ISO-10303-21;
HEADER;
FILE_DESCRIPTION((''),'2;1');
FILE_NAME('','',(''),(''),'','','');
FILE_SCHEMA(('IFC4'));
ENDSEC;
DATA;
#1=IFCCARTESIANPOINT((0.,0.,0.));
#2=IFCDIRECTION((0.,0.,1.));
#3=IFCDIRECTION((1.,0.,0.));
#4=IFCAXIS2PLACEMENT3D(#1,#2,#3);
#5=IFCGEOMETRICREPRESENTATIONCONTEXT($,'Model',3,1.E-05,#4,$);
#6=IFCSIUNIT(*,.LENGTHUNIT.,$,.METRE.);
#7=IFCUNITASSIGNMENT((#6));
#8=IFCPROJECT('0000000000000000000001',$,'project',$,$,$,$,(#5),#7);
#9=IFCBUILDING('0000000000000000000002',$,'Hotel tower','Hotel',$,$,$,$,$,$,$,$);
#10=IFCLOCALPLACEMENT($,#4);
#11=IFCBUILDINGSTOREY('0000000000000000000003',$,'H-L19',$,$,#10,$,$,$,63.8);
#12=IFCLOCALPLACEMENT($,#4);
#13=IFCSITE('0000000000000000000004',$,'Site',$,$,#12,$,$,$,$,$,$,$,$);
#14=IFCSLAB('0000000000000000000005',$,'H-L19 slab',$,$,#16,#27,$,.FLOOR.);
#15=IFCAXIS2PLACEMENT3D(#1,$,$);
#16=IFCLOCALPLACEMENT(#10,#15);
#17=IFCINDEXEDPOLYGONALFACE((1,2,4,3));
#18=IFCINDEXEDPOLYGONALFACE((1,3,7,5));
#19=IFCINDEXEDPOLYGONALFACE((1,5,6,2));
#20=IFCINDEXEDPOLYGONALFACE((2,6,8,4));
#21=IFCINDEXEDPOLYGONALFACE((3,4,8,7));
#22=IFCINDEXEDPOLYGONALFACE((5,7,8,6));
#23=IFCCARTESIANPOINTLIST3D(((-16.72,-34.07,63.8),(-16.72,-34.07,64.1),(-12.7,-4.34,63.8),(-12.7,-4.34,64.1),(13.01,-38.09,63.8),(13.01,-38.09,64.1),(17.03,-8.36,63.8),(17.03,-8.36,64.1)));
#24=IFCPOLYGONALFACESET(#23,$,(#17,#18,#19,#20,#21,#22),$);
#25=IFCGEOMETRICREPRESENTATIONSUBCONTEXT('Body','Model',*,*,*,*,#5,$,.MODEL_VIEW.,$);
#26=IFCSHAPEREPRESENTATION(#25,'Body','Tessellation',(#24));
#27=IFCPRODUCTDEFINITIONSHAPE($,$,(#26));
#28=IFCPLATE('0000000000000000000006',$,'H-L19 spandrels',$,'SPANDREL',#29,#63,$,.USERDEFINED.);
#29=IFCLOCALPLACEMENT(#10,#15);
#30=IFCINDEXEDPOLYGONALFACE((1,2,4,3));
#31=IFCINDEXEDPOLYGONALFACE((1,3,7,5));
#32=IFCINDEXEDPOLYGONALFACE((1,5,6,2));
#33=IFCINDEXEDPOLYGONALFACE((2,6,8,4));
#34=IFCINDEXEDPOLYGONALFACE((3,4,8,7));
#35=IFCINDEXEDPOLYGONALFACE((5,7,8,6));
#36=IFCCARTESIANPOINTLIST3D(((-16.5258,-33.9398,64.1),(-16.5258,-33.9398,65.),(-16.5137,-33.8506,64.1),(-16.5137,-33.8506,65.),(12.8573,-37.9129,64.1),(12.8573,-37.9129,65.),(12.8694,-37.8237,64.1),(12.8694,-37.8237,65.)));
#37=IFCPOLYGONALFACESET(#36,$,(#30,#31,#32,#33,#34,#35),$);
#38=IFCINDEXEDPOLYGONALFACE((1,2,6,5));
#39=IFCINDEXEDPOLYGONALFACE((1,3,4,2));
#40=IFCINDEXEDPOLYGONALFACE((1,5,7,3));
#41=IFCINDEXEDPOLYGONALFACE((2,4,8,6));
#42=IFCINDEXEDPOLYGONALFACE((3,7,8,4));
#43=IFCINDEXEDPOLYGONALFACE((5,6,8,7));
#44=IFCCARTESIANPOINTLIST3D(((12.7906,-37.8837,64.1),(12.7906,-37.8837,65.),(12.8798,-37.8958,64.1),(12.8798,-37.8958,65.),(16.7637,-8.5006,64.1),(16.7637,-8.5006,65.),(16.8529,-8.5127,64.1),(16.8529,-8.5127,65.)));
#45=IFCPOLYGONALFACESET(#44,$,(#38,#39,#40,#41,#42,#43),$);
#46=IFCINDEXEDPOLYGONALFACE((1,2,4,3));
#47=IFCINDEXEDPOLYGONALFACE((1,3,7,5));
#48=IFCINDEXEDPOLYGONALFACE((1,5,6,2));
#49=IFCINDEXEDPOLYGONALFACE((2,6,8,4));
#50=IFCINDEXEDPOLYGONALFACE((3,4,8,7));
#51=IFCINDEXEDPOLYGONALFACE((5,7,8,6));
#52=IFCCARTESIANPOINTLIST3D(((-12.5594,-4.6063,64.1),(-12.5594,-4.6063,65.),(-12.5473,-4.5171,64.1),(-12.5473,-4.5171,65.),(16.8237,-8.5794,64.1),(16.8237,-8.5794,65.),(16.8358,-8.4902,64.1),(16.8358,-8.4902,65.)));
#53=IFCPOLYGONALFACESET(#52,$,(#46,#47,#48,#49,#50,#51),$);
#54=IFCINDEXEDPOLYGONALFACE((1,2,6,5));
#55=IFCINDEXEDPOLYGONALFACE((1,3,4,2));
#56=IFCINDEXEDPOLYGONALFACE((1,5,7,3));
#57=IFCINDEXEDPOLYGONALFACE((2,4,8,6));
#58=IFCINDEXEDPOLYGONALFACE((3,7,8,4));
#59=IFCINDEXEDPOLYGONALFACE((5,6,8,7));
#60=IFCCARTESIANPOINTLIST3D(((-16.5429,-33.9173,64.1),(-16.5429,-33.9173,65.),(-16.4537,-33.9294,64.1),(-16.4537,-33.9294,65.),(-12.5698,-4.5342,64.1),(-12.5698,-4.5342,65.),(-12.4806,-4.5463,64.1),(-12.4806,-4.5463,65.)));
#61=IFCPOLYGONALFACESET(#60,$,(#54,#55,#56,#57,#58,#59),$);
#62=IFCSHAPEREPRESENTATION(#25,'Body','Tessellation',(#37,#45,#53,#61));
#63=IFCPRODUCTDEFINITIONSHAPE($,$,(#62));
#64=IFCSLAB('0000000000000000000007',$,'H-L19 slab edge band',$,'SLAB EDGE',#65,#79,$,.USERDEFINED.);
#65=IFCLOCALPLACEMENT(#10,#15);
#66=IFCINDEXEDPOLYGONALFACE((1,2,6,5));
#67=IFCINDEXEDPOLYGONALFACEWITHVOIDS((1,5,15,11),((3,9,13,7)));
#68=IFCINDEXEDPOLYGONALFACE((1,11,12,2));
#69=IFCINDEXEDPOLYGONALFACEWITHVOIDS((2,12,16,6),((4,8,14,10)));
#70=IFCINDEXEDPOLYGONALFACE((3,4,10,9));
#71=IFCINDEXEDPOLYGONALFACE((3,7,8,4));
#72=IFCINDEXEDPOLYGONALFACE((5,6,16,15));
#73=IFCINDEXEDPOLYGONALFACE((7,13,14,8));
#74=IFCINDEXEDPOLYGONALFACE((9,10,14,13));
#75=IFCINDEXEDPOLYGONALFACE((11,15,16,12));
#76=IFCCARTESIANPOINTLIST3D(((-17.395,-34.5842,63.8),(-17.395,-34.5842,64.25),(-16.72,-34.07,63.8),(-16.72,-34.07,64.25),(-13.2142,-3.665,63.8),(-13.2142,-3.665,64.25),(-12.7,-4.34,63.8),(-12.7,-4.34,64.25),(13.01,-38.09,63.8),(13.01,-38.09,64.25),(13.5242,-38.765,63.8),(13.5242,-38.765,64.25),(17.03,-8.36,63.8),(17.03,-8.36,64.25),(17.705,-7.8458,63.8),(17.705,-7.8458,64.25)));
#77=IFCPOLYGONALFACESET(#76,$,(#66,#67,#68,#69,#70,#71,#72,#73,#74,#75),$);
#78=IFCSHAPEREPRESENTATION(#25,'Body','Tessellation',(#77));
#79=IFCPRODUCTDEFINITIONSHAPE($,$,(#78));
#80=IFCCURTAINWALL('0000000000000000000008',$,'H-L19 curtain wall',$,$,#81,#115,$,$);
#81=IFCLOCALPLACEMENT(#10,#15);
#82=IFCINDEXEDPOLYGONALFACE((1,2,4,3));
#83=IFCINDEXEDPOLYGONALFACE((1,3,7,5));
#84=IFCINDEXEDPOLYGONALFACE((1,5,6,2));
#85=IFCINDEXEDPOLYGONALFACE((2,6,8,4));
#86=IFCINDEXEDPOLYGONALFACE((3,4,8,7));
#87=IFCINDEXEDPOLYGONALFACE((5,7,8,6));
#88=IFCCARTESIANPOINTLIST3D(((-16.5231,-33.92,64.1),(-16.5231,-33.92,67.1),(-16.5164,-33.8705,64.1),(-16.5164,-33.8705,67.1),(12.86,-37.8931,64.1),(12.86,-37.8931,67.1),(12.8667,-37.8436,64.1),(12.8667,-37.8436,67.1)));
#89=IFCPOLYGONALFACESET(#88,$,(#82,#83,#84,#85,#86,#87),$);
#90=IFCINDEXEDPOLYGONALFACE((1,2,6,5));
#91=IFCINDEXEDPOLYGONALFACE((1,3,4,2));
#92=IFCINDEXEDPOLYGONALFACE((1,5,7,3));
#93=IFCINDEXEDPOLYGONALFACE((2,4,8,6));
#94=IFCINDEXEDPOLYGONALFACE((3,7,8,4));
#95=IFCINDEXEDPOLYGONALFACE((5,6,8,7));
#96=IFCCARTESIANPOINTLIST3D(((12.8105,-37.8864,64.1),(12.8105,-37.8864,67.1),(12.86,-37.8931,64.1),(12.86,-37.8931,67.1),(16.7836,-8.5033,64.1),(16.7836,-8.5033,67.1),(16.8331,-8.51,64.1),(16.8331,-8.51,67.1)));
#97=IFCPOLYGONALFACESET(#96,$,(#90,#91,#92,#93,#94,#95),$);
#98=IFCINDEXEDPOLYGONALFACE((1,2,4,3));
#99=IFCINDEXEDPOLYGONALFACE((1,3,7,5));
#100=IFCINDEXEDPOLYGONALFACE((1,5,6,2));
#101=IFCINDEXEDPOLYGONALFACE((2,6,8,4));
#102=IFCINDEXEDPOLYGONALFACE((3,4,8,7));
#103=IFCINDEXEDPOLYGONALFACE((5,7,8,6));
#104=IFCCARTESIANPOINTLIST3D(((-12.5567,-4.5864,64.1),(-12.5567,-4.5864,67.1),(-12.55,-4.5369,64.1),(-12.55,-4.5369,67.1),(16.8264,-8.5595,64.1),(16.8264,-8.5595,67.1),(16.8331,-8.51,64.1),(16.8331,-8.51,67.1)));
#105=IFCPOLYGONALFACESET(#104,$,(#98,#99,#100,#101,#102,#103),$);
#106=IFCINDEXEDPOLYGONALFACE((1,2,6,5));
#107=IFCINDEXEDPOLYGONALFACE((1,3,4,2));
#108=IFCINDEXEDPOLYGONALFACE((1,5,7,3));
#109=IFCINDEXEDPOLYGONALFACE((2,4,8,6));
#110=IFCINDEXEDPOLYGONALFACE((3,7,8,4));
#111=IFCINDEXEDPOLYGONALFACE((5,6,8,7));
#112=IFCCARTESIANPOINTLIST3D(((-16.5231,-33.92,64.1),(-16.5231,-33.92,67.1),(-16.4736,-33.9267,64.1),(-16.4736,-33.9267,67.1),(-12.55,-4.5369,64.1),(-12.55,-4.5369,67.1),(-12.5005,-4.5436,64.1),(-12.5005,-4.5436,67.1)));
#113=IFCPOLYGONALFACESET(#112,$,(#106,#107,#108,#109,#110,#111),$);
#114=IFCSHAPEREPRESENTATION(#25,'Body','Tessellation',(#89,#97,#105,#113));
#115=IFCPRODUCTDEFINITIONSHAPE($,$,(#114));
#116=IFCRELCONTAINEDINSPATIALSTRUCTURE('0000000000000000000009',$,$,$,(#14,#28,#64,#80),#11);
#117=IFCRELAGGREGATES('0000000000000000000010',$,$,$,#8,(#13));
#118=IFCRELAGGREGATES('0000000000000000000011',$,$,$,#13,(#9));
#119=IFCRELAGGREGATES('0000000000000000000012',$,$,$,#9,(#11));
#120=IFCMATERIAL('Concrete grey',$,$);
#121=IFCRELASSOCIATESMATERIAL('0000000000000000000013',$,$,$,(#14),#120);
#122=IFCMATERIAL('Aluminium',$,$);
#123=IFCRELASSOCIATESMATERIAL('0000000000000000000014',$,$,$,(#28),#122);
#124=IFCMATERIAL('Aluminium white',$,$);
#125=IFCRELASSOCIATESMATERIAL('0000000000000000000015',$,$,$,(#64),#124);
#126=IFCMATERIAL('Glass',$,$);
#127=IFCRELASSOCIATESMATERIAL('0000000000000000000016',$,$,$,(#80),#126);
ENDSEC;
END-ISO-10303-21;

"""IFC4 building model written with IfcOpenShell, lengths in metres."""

from ifc_helpers import new_model, si_unit, frame, origin_with_axes, place, context, subcontext, project, spatial, polyline, outline, extrude, material, element, save


model = new_model("IFC4")

# Units and contexts
model_context = context("Model", 3, precision=1e-05, world=origin_with_axes())
body_context = subcontext(model_context, "Body", "Model", "MODEL_VIEW")
ifc_project = project(units=[si_unit("LENGTHUNIT", "METRE")], contexts=[model_context])

# Site, building, storey
site_placement = place(None, origin_with_axes())
site = spatial("IfcSite", under=ifc_project, at=site_placement, Name="Site")
building = spatial("IfcBuilding", under=site, Name="Hotel tower", Description="Hotel")
storey_placement = place(None, origin_with_axes())
storey = spatial("IfcBuildingStorey", under=building, at=storey_placement, Name="H-L19", Elevation=63.8)

# Shared definitions
ifc_material_1 = material(Name="Aluminium")

# Slab
ifc_material_2 = material(Name="Concrete grey")
slab_1_placement = place(storey_placement, origin_with_axes())
element("IfcSlab", 1, at=slab_1_placement, inside=storey, material=ifc_material_2, Name="H-L19 slab", PredefinedType="FLOOR", context=body_context, shape_type="SweptSolid", body=[
    extrude(outline(polyline([(-16.72, -34.07), (13.01, -38.09), (17.03, -8.36), (-12.7, -4.34), (-16.72, -34.07)])), frame((0.0, 0.0, 63.8), z_axis=(0.0, 0.0, 1.0), x_axis=(1.0, 0.0, 0.0)), (0.0, 0.0, 1.0), 0.3),
])

# Plate
plate_placement = place(storey_placement, origin_with_axes())
element("IfcPlate", 2, at=plate_placement, inside=storey, material=ifc_material_1, Name="H-L19 spandrels", ObjectType="SPANDREL", PredefinedType="USERDEFINED", context=body_context, shape_type="SweptSolid", body=[
    extrude(outline(polyline([(-16.5258, -33.9398), (12.8573, -37.9129), (12.8694, -37.8237), (-16.5137, -33.8506), (-16.5258, -33.9398)])), frame((0.0, 0.0, 64.1), z_axis=(0.0, 0.0, 1.0), x_axis=(1.0, 0.0, 0.0)), (0.0, 0.0, 1.0), 0.9),
    extrude(outline(polyline([(12.8798, -37.8958), (16.8529, -8.5127), (16.7637, -8.5006), (12.7906, -37.8837), (12.8798, -37.8958)])), frame((0.0, 0.0, 64.1), z_axis=(0.0, 0.0, 1.0), x_axis=(1.0, 0.0, 0.0)), (0.0, 0.0, 1.0), 0.9),
    extrude(outline(polyline([(16.8358, -8.4902), (-12.5473, -4.5171), (-12.5594, -4.6063), (16.8237, -8.5794), (16.8358, -8.4902)])), frame((0.0, 0.0, 64.1), z_axis=(0.0, 0.0, 1.0), x_axis=(1.0, 0.0, 0.0)), (0.0, 0.0, 1.0), 0.9),
    extrude(outline(polyline([(-12.5698, -4.5342), (-16.5429, -33.9173), (-16.4537, -33.9294), (-12.4806, -4.5463), (-12.5698, -4.5342)])), frame((0.0, 0.0, 64.1), z_axis=(0.0, 0.0, 1.0), x_axis=(1.0, 0.0, 0.0)), (0.0, 0.0, 1.0), 0.9),
])

# Slab
ifc_material_3 = material(Name="Aluminium white")
slab_2_placement = place(storey_placement, origin_with_axes())
element("IfcSlab", 3, at=slab_2_placement, inside=storey, material=ifc_material_3, Name="H-L19 slab edge band", ObjectType="SLAB EDGE", PredefinedType="USERDEFINED", context=body_context, shape_type="SweptSolid", body=[
    extrude(outline(polyline([(-17.395, -34.5842), (13.5242, -38.765), (17.705, -7.8458), (-13.2142, -3.665), (-17.395, -34.5842)]), holes=[polyline([(-16.72, -34.07), (13.01, -38.09), (17.03, -8.36), (-12.7, -4.34), (-16.72, -34.07)])]), frame((0.0, 0.0, 63.8), z_axis=(0.0, 0.0, 1.0), x_axis=(1.0, 0.0, 0.0)), (0.0, 0.0, 1.0), 0.45),
])

# Curtain wall
ifc_material_4 = material(Name="Glass")
curtain_wall_placement = place(storey_placement, origin_with_axes())
element("IfcCurtainWall", 4, at=curtain_wall_placement, inside=storey, material=ifc_material_4, Name="H-L19 curtain wall", context=body_context, shape_type="SweptSolid", body=[
    extrude(outline(polyline([(-16.5231, -33.92), (12.86, -37.8931), (12.8667, -37.8436), (-16.5164, -33.8705), (-16.5231, -33.92)])), frame((0.0, 0.0, 64.1), z_axis=(0.0, 0.0, 1.0), x_axis=(1.0, 0.0, 0.0)), (0.0, 0.0, 1.0), 3.0),
    extrude(outline(polyline([(12.86, -37.8931), (16.8331, -8.51), (16.7836, -8.5033), (12.8105, -37.8864), (12.86, -37.8931)])), frame((0.0, 0.0, 64.1), z_axis=(0.0, 0.0, 1.0), x_axis=(1.0, 0.0, 0.0)), (0.0, 0.0, 1.0), 3.0),
    extrude(outline(polyline([(16.8331, -8.51), (-12.55, -4.5369), (-12.5567, -4.5864), (16.8264, -8.5595), (16.8331, -8.51)])), frame((0.0, 0.0, 64.1), z_axis=(0.0, 0.0, 1.0), x_axis=(1.0, 0.0, 0.0)), (0.0, 0.0, 1.0), 3.0),
    extrude(outline(polyline([(-12.55, -4.5369), (-16.5231, -33.92), (-16.4736, -33.9267), (-12.5005, -4.5436), (-12.55, -4.5369)])), frame((0.0, 0.0, 64.1), z_axis=(0.0, 0.0, 1.0), x_axis=(1.0, 0.0, 0.0)), (0.0, 0.0, 1.0), 3.0),
])

save(model, "model.ifc")
